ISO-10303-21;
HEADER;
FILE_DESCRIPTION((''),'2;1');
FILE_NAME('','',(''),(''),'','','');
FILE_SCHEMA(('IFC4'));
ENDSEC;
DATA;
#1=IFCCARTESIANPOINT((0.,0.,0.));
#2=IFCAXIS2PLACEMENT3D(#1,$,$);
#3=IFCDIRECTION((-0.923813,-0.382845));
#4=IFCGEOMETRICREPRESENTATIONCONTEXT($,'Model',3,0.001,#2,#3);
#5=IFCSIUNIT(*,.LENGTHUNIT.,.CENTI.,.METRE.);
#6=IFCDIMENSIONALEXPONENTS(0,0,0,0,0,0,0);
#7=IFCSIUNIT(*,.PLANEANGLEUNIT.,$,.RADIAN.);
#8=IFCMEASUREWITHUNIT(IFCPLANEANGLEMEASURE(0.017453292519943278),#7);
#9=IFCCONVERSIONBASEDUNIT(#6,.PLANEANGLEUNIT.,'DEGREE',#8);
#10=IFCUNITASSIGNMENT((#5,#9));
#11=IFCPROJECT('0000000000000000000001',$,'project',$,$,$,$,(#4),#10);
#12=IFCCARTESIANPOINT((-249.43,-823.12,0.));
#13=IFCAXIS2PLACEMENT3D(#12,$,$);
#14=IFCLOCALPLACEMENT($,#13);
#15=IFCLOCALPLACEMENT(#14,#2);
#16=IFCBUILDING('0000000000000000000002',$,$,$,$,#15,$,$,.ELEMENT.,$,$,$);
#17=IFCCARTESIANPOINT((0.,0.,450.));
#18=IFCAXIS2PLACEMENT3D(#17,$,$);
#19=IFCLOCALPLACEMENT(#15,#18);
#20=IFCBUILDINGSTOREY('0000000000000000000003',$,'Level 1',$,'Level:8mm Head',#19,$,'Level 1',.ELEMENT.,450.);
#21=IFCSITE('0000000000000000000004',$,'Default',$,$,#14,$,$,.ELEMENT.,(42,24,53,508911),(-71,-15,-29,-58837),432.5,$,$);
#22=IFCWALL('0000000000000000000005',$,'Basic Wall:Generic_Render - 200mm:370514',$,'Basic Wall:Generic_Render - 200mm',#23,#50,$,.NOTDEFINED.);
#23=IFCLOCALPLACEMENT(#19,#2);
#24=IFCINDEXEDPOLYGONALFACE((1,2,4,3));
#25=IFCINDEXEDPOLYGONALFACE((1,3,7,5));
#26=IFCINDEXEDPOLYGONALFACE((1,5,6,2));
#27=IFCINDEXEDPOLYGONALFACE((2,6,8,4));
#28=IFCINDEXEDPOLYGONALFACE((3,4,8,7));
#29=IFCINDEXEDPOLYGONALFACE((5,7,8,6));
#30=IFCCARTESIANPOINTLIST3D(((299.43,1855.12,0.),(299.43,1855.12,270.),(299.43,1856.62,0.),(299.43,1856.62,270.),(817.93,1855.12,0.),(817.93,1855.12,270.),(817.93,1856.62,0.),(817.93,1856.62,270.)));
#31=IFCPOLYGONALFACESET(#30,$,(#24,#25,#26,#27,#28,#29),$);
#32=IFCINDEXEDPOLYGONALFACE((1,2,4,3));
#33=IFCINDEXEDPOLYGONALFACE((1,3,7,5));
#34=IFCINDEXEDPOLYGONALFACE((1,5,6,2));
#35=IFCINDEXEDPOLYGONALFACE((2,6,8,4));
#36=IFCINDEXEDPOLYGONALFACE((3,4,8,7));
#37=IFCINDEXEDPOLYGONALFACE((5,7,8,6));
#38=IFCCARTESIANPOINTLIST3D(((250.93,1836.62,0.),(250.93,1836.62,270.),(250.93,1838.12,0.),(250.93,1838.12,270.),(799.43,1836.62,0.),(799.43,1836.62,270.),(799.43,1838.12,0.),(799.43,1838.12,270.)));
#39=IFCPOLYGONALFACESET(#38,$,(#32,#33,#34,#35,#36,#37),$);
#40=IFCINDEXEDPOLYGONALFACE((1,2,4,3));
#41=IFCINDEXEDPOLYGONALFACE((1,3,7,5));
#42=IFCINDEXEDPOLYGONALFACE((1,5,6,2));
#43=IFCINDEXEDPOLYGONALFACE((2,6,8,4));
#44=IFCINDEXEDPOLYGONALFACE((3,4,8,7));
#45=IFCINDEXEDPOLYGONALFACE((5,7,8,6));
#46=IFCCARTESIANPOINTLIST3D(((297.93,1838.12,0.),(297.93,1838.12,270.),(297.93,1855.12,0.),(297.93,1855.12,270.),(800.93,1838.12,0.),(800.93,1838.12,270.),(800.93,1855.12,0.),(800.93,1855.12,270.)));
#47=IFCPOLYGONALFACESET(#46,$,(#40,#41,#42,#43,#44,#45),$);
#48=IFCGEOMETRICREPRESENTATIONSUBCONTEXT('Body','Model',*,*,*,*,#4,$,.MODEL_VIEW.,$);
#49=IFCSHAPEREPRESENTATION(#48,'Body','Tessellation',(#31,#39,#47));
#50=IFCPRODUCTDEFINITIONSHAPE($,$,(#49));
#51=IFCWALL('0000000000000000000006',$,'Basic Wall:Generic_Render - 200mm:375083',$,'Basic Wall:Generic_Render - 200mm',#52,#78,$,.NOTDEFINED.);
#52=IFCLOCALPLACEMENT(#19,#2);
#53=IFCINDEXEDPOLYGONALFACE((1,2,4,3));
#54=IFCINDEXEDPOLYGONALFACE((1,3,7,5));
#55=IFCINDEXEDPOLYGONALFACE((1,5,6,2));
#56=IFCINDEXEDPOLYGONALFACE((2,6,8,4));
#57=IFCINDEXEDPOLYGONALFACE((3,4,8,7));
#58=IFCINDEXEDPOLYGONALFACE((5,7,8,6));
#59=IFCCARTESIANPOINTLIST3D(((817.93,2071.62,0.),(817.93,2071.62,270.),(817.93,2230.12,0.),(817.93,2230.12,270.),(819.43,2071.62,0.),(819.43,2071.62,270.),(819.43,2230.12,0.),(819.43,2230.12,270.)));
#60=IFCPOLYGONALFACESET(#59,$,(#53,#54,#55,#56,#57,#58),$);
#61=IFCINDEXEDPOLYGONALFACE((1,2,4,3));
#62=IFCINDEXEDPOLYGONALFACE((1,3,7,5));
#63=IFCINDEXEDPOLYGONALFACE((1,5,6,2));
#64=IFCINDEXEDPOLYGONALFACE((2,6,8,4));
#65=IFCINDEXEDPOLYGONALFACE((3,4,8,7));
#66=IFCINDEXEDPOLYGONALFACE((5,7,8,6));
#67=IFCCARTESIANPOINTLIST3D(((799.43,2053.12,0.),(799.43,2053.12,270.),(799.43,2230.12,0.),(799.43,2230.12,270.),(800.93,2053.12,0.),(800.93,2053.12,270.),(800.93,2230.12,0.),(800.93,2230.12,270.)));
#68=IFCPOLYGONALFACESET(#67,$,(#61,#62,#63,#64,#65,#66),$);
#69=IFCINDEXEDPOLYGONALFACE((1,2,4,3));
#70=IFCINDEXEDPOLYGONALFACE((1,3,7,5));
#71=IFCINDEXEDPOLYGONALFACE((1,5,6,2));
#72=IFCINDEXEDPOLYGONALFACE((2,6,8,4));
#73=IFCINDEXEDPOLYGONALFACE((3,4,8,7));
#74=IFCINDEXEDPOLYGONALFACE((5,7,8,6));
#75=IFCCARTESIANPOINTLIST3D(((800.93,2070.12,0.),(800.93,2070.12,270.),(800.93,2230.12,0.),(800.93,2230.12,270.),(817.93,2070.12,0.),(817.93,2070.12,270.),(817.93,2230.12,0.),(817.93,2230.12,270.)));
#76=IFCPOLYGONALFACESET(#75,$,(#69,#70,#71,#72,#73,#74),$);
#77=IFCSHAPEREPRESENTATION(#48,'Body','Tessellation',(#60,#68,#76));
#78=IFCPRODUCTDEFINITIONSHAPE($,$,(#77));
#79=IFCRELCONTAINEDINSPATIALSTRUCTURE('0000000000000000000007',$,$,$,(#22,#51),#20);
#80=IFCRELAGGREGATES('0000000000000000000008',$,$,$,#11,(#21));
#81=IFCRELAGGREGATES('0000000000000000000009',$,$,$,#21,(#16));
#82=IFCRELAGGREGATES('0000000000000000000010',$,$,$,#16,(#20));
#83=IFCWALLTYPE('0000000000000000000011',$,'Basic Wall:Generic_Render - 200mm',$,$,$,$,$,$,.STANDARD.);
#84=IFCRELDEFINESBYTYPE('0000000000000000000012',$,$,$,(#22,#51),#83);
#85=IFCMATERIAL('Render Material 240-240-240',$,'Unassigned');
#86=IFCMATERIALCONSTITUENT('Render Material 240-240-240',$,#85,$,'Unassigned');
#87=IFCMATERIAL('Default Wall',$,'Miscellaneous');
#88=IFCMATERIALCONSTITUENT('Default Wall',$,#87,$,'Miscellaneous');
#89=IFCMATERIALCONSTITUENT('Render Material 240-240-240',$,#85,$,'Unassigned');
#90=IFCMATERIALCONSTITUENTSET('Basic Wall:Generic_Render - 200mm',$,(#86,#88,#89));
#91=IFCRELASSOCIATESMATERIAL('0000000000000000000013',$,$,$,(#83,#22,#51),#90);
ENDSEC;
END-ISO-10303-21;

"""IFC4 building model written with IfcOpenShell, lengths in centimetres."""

from ifc_helpers import new_model, entity, si_unit, converted_unit, direction, frame, origin, place, context, subcontext, project, spatial, indexed_curve, outline, extrude, material, constituent, constituent_set, type_object, element, save


model = new_model("IFC4")

# Units and contexts
model_context = context("Model", 3, precision=0.001, world=origin(), true_north=direction((-0.923813, -0.382845)))
body_context = subcontext(model_context, "Body", "Model", "MODEL_VIEW")
ifc_project = project(units=[si_unit("LENGTHUNIT", "METRE", prefix="CENTI"), converted_unit("PLANEANGLEUNIT", "DEGREE", entity("IfcPlaneAngleMeasure", 0.017453292519943278), si_unit("PLANEANGLEUNIT", "RADIAN"), dimensions=[0, 0, 0, 0, 0, 0, 0])], contexts=[model_context])

# Site, building, storey
site_placement = place(None, frame((-249.43, -823.12, 0.0)))
site = spatial("IfcSite", under=ifc_project, at=site_placement, Name="Default", CompositionType="ELEMENT", RefLatitude=(42, 24, 53, 508911), RefLongitude=(-71, -15, -29, -58837), RefElevation=432.5)
building_placement = place(site_placement, origin())
building = spatial("IfcBuilding", under=site, at=building_placement, CompositionType="ELEMENT")
storey_placement = place(building_placement, frame((0.0, 0.0, 450.0)))
storey = spatial("IfcBuildingStorey", under=building, at=storey_placement, Name="Level 1", ObjectType="Level:8mm Head", LongName="Level 1", CompositionType="ELEMENT", Elevation=450.0)

# Shared definitions
ifc_material_1 = material(Name="Render Material 240-240-240", Category="Unassigned")
ifc_material_2 = material(Name="Default Wall", Category="Miscellaneous")

# Shared definitions
ifc_constituent_1 = constituent(ifc_material_1, Name="Render Material 240-240-240", Category="Unassigned")
ifc_constituent_2 = constituent(ifc_material_2, Name="Default Wall", Category="Miscellaneous")
ifc_constituent_3 = constituent(ifc_material_1, Name="Render Material 240-240-240", Category="Unassigned")
ifc_constituent_set_1 = constituent_set(constituents=[ifc_constituent_1, ifc_constituent_2, ifc_constituent_3], Name="Basic Wall:Generic_Render - 200mm")
wall_type_1 = type_object("IfcWallType", Name="Basic Wall:Generic_Render - 200mm", PredefinedType="STANDARD", material=ifc_constituent_set_1)

# Wall
wall_1_placement = place(storey_placement, frame((799.43, 1846.62, 0.0), z_axis=(0.0, 0.0, 1.0), x_axis=(-1.0, 0.0, 0.0)))
element("IfcWall", 1, at=wall_1_placement, inside=storey, type_object=wall_type_1, material=ifc_constituent_set_1, Name="Basic Wall:Generic_Render - 200mm:370514", ObjectType="Basic Wall:Generic_Render - 200mm", PredefinedType="NOTDEFINED", context=body_context, shape_type="SweptSolid", body=[
    extrude(outline(indexed_curve([(-0.75, -259.25), (0.75, -259.25), (0.75, 259.25), (-0.75, 259.25), (-0.75, -259.25)], self_intersect=False)), frame((240.75, -9.25, 0.0), z_axis=(0.0, 0.0, 1.0), x_axis=(0.0, 1.0, 0.0)), (0.0, 0.0, 1.0), 270.0),
    extrude(outline(indexed_curve([(-0.75, -274.25), (0.75, -274.25), (0.75, 274.25), (-0.75, 274.25), (-0.75, -274.25)], self_intersect=False)), frame((274.25, 9.25, 0.0), z_axis=(0.0, 0.0, 1.0), x_axis=(0.0, -1.0, 0.0)), (0.0, 0.0, 1.0), 270.0),
    extrude(outline(indexed_curve([(-251.5, -8.5), (251.5, -8.5), (251.5, 8.5), (-251.5, 8.5), (-251.5, -8.5)], self_intersect=False)), frame((250.0, 0.0, 0.0)), (0.0, 0.0, 1.0), 270.0),
])

# Wall
wall_2_placement = place(storey_placement, frame((809.43, 2071.62, 0.0), z_axis=(0.0, 0.0, 1.0), x_axis=(0.0, 1.0, 0.0)))
element("IfcWall", 2, at=wall_2_placement, inside=storey, type_object=wall_type_1, material=ifc_constituent_set_1, Name="Basic Wall:Generic_Render - 200mm:375083", ObjectType="Basic Wall:Generic_Render - 200mm", PredefinedType="NOTDEFINED", context=body_context, shape_type="SweptSolid", body=[
    extrude(outline(indexed_curve([(-0.75, -79.25), (0.75, -79.25), (0.75, 79.25), (-0.75, 79.25), (-0.75, -79.25)], self_intersect=False)), frame((79.25, -9.25, 0.0), z_axis=(0.0, 0.0, 1.0), x_axis=(0.0, 1.0, 0.0)), (0.0, 0.0, 1.0), 270.0),
    extrude(outline(indexed_curve([(-0.75, -88.5), (0.75, -88.5), (0.75, 88.5), (-0.75, 88.5), (-0.75, -88.5)], self_intersect=False)), frame((70.0, 9.25, 0.0), z_axis=(0.0, 0.0, 1.0), x_axis=(0.0, -1.0, 0.0)), (0.0, 0.0, 1.0), 270.0),
    extrude(outline(indexed_curve([(-80.0, -8.5), (80.0, -8.5), (80.0, 8.5), (-80.0, 8.5), (-80.0, -8.5)], self_intersect=False)), frame((78.5, 0.0, 0.0)), (0.0, 0.0, 1.0), 270.0),
])

save(model, "model.ifc")
